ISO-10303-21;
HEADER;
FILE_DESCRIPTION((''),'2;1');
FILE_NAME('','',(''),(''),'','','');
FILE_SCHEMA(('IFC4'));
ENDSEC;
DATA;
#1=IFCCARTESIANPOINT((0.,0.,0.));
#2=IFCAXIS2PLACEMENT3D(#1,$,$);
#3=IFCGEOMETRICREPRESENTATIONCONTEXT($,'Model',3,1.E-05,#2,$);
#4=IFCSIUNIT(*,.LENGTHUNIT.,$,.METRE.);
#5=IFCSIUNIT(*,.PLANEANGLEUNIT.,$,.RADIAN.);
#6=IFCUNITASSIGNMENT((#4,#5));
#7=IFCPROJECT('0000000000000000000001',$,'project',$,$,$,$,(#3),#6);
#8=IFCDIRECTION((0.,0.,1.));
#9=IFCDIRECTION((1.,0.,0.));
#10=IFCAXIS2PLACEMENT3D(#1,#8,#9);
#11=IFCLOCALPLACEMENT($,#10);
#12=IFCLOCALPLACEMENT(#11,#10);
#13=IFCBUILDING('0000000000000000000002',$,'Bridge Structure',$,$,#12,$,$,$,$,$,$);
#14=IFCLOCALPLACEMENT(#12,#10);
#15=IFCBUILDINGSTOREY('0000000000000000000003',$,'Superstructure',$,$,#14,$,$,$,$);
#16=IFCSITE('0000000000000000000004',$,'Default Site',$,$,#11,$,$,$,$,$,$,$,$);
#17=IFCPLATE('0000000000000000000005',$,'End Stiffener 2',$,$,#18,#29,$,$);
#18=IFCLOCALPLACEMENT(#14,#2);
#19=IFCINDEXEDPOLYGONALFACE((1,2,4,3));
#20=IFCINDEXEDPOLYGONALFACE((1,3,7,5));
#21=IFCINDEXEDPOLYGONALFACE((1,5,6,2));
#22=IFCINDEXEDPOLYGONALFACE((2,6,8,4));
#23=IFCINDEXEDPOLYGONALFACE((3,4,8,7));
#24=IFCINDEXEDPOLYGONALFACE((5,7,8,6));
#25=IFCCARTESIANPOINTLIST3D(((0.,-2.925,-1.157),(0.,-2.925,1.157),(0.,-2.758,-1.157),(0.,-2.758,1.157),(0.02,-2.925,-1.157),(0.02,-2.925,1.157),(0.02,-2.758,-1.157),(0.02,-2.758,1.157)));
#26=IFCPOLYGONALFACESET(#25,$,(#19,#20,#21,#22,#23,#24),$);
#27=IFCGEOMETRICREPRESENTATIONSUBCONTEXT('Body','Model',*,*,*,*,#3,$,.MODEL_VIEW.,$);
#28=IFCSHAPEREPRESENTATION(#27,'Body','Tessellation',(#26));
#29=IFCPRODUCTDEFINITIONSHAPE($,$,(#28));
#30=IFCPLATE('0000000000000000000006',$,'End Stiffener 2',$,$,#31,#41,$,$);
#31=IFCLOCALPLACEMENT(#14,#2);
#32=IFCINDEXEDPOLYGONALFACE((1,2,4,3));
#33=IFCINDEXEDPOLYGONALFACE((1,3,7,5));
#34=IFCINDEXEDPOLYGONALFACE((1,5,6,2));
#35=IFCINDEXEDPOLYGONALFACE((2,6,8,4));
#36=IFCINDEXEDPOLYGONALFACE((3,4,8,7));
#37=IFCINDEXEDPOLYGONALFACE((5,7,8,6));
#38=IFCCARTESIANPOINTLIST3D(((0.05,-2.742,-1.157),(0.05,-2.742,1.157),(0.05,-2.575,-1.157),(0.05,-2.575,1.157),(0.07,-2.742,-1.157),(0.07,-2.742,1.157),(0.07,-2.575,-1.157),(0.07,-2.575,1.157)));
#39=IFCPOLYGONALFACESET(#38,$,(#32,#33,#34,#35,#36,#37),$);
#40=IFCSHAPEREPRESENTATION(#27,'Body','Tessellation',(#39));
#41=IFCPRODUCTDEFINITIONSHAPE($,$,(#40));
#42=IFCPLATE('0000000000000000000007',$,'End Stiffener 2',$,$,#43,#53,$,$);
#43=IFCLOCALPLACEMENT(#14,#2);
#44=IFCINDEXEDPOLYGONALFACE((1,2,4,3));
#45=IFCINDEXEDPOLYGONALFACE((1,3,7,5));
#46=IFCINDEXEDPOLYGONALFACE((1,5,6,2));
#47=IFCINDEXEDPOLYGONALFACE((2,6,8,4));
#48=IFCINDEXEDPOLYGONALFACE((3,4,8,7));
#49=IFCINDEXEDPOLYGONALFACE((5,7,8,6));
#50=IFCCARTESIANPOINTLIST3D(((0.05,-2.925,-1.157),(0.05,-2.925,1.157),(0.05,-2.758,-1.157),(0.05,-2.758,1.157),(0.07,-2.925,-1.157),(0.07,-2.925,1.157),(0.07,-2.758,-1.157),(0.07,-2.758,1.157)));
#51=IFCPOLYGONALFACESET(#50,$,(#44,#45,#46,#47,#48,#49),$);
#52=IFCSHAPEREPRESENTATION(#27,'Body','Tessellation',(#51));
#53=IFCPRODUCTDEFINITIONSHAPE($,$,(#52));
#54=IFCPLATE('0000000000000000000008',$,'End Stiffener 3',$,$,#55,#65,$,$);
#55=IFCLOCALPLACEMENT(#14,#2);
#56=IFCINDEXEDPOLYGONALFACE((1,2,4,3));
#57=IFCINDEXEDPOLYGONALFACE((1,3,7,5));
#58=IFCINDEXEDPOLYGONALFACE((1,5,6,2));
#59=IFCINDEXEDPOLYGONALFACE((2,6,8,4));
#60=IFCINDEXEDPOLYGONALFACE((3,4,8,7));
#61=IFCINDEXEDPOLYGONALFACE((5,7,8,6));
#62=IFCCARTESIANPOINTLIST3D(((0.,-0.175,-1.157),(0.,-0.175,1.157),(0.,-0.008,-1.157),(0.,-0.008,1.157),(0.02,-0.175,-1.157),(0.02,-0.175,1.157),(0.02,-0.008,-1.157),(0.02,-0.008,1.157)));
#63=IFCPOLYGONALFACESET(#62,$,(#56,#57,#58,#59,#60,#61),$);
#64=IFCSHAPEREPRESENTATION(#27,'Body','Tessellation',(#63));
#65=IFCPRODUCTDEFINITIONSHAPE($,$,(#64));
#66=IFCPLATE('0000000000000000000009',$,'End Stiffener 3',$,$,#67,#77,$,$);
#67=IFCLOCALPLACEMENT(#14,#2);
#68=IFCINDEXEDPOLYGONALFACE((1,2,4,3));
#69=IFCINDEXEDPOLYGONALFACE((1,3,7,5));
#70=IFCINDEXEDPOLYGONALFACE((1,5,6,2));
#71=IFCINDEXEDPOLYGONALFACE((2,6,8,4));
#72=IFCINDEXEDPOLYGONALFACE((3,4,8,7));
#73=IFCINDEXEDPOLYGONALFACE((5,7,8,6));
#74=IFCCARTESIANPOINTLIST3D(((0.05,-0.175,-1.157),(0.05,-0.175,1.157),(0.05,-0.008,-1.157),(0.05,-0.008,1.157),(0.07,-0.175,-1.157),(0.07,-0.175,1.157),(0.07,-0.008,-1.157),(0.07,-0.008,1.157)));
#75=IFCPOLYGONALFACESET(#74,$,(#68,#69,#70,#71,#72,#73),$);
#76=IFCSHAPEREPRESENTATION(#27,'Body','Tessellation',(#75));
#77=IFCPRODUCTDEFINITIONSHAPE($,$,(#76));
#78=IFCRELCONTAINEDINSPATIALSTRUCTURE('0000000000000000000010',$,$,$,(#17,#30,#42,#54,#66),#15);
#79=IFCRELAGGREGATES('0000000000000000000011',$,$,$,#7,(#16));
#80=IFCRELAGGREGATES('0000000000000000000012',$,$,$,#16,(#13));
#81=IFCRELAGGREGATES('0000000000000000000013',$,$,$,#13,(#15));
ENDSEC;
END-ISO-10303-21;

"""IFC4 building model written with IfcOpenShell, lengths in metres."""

from ifc_helpers import new_model, si_unit, frame, origin, origin_with_axes, origin_2d_with_axis, place, context, subcontext, project, spatial, rectangle, extrude, element, save


model = new_model("IFC4")

# Units and contexts
model_context = context("Model", 3, precision=1e-05, world=origin())
body_context = subcontext(model_context, "Body", "Model", "MODEL_VIEW")
ifc_project = project(units=[si_unit("LENGTHUNIT", "METRE"), si_unit("PLANEANGLEUNIT", "RADIAN")], contexts=[model_context])

# Site, building, storey
site_placement = place(None, origin_with_axes())
site = spatial("IfcSite", under=ifc_project, at=site_placement, Name="Default Site")
building_placement = place(site_placement, origin_with_axes())
building = spatial("IfcBuilding", under=site, at=building_placement, Name="Bridge Structure")
storey_placement = place(building_placement, origin_with_axes())
storey = spatial("IfcBuildingStorey", under=building, at=storey_placement, Name="Superstructure")

# Plates
for number, where, z_axis, x_axis, name in (
    (1, (0.01, -2.8415, -1.157), (0.0, 0.0, 1.0), (1.0, 0.0, 0.0), "End Stiffener 2"),
    (2, (0.06, -2.6585, -1.157), (0.0, 0.0, 1.0), (1.0, 0.0, 0.0), "End Stiffener 2"),
    (3, (0.06, -2.8415, -1.157), (0.0, 0.0, 1.0), (1.0, 0.0, 0.0), "End Stiffener 2"),
    (4, (0.01, -0.0915, -1.157), (0.0, 0.0, 1.0), (1.0, 0.0, 0.0), "End Stiffener 3"),
    (5, (0.06, -0.0915, -1.157), (0.0, 0.0, 1.0), (1.0, 0.0, 0.0), "End Stiffener 3"),
):
    element("IfcPlate", number, at=place(storey_placement, frame(where, z_axis=z_axis, x_axis=x_axis)), inside=storey, Name=name, context=body_context, shape_type="SweptSolid", body=[
        extrude(rectangle(XDim=0.02, YDim=0.167, at=origin_2d_with_axis()), origin_with_axes(), (0.0, 0.0, 1.0), 2.314),
    ])

save(model, "model.ifc")
